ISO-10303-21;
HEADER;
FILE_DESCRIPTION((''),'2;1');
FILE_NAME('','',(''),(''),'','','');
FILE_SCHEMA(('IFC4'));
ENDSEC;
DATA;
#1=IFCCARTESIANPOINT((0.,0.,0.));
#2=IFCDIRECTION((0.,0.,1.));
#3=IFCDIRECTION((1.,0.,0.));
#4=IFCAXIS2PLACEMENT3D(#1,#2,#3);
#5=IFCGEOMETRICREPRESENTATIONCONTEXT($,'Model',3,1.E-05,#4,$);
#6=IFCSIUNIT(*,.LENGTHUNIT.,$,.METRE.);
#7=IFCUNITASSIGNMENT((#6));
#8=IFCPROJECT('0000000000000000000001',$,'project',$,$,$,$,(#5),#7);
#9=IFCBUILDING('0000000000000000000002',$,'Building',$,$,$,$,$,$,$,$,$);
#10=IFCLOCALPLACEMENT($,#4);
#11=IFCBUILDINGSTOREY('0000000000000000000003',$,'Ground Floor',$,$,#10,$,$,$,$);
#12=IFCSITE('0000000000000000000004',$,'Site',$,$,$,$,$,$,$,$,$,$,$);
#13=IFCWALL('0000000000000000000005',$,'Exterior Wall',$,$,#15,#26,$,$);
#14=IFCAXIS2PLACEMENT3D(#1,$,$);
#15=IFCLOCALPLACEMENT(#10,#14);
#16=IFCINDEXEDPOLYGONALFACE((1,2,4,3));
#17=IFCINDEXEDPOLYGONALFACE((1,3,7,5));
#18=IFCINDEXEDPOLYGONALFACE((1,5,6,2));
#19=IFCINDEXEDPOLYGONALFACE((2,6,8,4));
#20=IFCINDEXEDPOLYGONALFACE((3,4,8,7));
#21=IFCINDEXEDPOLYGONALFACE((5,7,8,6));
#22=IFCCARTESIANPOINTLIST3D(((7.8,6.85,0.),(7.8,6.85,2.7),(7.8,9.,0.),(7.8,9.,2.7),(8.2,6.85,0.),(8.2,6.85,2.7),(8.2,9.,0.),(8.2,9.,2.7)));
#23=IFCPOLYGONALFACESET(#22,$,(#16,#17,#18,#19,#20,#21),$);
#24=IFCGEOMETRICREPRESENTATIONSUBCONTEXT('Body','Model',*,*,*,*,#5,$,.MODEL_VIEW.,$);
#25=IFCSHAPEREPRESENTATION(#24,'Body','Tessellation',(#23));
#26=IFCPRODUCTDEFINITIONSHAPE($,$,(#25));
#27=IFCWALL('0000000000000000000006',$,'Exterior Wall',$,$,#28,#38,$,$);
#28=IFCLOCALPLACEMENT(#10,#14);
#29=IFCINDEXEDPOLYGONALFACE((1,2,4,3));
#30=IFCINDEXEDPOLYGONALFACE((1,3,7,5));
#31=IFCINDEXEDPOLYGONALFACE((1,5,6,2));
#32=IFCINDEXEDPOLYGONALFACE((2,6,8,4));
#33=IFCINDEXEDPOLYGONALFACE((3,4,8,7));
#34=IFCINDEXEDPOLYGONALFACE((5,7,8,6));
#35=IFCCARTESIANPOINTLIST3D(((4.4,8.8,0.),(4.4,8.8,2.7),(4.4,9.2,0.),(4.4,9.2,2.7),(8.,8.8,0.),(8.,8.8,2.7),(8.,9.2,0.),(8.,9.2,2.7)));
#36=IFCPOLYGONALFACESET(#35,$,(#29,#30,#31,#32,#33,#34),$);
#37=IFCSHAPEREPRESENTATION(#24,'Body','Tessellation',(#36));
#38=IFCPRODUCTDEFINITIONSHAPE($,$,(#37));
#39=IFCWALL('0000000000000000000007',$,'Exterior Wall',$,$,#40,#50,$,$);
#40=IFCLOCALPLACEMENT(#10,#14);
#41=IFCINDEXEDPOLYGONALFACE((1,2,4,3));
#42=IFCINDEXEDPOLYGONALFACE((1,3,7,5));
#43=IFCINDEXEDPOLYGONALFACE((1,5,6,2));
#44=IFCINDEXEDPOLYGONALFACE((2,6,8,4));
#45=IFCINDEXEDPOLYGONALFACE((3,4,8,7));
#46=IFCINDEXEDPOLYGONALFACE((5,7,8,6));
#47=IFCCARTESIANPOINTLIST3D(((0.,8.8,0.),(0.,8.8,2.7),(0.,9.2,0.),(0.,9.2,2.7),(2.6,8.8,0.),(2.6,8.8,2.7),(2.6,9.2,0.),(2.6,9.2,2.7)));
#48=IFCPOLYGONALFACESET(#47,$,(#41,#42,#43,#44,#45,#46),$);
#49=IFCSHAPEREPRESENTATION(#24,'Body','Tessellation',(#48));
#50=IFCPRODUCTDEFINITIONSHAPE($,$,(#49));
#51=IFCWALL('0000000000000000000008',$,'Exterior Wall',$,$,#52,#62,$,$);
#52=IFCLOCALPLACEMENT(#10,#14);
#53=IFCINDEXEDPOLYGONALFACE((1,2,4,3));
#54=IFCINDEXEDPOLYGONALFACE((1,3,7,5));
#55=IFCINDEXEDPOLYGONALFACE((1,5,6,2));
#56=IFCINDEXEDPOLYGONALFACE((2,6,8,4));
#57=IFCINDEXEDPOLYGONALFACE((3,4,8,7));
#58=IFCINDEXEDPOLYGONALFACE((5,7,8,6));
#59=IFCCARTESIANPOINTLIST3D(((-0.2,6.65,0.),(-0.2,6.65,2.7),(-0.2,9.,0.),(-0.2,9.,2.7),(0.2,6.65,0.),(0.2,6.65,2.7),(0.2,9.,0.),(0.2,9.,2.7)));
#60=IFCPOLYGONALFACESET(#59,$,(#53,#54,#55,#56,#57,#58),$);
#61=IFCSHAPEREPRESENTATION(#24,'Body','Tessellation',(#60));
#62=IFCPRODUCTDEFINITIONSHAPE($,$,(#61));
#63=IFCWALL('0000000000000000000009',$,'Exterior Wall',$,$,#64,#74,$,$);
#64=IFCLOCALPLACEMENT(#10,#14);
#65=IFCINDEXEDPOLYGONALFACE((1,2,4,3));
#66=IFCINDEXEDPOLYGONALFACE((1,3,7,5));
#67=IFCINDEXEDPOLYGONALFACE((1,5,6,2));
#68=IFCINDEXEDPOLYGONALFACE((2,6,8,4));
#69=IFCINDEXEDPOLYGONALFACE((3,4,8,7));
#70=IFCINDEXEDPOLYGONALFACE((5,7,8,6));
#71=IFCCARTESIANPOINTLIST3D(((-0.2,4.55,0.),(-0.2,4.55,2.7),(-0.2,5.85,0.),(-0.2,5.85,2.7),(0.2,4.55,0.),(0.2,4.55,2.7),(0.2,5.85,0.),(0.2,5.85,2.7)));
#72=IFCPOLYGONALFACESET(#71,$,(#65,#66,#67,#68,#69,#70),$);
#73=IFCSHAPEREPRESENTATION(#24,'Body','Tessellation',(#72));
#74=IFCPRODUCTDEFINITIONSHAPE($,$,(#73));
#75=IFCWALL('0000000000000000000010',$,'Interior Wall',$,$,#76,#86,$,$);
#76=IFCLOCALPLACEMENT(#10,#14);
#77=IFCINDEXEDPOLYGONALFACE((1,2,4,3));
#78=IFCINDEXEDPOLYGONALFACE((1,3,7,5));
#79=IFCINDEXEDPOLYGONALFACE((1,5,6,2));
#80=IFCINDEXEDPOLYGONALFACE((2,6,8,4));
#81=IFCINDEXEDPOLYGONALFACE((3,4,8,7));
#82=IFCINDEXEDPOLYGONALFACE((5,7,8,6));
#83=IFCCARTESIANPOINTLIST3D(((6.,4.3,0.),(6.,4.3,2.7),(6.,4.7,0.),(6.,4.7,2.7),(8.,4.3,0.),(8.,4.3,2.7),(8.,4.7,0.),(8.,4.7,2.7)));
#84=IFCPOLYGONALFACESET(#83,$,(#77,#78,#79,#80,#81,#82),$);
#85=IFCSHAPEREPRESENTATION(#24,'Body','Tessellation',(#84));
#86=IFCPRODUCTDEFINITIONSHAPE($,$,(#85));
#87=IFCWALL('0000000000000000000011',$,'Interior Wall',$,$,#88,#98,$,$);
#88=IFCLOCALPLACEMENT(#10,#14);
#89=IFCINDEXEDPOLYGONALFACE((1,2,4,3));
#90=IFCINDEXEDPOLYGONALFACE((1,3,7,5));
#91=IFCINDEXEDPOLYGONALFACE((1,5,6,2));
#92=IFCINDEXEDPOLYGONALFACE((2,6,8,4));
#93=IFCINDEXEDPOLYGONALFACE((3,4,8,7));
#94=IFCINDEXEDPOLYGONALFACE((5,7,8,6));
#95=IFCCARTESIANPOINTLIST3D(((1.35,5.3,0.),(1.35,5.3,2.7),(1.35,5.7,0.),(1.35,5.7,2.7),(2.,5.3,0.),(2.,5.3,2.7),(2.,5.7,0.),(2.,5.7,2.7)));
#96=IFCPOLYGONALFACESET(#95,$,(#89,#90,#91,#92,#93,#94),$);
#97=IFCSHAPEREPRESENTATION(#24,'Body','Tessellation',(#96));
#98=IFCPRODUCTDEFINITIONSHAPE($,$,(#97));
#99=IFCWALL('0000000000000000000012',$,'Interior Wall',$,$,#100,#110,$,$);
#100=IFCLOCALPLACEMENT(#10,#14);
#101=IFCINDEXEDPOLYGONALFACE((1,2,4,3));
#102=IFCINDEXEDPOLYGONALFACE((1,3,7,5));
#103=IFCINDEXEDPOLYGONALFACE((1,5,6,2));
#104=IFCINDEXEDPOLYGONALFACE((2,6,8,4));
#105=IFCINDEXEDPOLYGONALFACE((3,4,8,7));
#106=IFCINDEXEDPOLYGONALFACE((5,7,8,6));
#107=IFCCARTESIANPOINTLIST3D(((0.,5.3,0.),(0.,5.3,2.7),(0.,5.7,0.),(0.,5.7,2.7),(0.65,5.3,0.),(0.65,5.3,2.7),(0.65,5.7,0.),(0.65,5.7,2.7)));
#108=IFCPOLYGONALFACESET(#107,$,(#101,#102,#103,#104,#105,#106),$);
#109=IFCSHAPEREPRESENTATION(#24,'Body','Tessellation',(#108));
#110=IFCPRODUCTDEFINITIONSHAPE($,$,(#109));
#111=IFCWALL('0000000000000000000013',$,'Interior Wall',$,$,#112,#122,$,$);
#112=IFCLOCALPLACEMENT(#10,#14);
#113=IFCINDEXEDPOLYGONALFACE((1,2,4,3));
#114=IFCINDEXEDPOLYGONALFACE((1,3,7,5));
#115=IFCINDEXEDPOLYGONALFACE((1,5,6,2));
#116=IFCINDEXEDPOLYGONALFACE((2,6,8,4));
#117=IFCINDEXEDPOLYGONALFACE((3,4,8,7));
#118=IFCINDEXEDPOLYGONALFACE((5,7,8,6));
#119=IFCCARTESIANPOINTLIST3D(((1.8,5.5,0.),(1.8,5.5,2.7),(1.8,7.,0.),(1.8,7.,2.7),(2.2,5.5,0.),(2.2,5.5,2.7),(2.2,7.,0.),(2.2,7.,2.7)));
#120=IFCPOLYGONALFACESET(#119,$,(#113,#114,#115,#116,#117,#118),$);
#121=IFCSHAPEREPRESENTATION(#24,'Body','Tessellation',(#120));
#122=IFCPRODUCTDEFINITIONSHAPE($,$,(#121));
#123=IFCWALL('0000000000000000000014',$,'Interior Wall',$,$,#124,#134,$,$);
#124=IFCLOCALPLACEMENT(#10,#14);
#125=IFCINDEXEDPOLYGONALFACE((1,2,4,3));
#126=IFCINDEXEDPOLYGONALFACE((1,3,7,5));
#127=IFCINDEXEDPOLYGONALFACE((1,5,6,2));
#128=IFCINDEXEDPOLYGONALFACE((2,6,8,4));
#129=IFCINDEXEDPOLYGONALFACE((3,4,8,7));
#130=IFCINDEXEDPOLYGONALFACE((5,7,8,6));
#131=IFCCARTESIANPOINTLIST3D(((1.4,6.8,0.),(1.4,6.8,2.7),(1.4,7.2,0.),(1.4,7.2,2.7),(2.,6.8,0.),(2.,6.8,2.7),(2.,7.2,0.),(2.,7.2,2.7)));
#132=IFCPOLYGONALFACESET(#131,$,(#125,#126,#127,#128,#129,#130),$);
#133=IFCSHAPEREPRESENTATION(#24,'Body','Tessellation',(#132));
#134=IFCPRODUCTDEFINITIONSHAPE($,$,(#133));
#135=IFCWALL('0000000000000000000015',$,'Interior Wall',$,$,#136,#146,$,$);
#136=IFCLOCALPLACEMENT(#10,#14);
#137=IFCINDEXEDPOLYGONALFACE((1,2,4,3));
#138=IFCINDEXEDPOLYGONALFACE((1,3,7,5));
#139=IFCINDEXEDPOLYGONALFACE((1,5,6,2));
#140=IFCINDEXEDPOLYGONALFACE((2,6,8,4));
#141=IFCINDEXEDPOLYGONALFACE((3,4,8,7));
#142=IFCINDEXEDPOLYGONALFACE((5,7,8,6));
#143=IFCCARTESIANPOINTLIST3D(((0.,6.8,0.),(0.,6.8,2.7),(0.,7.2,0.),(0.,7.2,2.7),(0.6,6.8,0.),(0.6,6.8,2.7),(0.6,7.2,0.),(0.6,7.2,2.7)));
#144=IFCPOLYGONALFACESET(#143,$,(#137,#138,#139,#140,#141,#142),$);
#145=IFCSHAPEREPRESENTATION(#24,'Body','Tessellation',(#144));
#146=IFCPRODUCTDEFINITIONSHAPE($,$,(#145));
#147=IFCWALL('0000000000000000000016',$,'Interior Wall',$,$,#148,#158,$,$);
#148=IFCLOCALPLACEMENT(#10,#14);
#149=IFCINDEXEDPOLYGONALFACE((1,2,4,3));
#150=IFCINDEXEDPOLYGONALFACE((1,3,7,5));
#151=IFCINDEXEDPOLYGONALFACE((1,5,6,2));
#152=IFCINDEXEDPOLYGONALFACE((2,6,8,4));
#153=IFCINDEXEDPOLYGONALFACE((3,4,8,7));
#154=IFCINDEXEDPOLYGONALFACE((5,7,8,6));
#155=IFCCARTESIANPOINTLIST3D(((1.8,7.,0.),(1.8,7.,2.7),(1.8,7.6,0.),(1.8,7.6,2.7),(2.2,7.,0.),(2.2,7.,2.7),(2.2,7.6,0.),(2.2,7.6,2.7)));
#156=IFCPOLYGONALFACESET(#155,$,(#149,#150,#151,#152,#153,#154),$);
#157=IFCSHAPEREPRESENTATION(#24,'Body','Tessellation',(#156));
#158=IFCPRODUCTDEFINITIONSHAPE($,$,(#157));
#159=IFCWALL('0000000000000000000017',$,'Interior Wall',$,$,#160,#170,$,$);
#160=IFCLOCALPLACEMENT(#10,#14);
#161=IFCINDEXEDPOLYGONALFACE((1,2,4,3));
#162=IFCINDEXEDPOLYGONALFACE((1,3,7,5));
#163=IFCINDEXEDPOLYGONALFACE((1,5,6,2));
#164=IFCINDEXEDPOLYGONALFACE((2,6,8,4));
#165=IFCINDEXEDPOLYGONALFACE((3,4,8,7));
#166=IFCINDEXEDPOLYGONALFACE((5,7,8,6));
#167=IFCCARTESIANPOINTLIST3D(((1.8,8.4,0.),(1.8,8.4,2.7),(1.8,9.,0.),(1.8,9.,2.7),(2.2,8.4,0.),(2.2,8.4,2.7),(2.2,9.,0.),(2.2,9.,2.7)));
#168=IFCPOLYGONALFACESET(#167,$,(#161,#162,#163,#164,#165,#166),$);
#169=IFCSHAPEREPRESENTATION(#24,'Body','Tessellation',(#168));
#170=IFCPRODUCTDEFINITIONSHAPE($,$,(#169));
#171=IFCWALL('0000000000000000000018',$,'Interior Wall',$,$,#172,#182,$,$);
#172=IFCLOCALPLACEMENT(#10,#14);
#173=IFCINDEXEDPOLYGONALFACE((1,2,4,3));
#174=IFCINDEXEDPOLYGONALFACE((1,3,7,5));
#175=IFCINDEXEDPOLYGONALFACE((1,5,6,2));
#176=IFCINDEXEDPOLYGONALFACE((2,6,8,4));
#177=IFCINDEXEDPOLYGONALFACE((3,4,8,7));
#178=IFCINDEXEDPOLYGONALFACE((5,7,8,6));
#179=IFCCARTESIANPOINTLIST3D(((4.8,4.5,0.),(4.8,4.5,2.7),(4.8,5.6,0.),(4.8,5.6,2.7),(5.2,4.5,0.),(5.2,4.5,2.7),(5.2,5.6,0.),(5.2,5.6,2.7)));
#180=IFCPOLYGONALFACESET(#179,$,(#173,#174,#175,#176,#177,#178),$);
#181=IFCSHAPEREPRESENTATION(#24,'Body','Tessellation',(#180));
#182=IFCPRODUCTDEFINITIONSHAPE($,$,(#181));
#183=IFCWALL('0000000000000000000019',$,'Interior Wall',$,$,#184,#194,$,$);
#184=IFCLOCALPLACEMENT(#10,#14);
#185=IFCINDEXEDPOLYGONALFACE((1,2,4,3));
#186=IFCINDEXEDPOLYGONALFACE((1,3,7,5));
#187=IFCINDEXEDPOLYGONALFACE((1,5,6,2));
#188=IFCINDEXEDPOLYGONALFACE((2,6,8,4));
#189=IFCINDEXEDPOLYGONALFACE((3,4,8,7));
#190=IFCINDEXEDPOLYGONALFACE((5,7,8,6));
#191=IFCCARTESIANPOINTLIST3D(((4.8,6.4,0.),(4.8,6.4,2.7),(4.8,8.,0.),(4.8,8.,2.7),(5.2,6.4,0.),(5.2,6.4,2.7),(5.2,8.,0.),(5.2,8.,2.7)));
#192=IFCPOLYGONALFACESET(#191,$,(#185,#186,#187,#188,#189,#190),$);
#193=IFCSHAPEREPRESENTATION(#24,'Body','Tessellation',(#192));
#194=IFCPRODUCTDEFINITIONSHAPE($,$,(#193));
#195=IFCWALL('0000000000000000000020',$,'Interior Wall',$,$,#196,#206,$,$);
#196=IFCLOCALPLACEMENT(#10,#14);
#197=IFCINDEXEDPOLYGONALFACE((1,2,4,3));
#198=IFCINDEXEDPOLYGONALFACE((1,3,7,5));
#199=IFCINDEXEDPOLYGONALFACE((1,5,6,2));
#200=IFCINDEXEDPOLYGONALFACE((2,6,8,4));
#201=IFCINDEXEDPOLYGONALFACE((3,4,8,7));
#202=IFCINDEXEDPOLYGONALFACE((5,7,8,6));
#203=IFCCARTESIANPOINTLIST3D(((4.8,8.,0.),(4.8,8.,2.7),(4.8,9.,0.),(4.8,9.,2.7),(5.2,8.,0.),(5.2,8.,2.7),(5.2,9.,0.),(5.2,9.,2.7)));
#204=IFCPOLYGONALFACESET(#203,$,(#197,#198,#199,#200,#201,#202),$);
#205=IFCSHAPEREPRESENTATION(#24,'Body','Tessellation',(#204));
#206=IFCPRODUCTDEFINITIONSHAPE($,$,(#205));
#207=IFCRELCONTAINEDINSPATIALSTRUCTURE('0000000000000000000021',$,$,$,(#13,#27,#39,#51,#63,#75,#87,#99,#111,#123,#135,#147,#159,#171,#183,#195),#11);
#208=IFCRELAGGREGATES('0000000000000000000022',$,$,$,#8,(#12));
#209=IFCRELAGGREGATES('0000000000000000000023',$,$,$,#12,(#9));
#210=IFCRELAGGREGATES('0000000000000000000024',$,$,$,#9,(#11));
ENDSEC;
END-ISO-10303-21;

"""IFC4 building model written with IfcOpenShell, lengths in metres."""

from ifc_helpers import new_model, si_unit, frame, origin_with_axes, place, context, subcontext, project, spatial, indexed_curve, outline, extrude, element, save


model = new_model("IFC4")

# Units and contexts
model_context = context("Model", 3, precision=1e-05, world=origin_with_axes())
body_context = subcontext(model_context, "Body", "Model", "MODEL_VIEW")
ifc_project = project(units=[si_unit("LENGTHUNIT", "METRE")], contexts=[model_context])

# Site, building, storey
site = spatial("IfcSite", under=ifc_project, Name="Site")
building = spatial("IfcBuilding", under=site, Name="Building")
storey_placement = place(None, origin_with_axes())
storey = spatial("IfcBuildingStorey", under=building, at=storey_placement, Name="Ground Floor")

# Walls
wall_1_placement = place(storey_placement, frame((8.0, 6.85, 0.0), z_axis=(0.0, 0.0, 1.0), x_axis=(0.0, 1.0, 0.0)))
element("IfcWall", 1, at=wall_1_placement, inside=storey, Name="Exterior Wall", context=body_context, shape_type="SweptSolid", body=[
    extrude(outline(indexed_curve([(0.0, 0.0), (0.0, 0.4), (2.15, 0.4), (2.15, 0.0), (0.0, 0.0)], self_intersect=False)), frame((0.0, -0.2, 0.0), z_axis=(0.0, 0.0, 1.0), x_axis=(1.0, 0.0, 0.0)), (0.0, 0.0, 1.0), 2.7),
])
wall_2_placement = place(storey_placement, frame((8.0, 9.0, 0.0), z_axis=(0.0, 0.0, 1.0), x_axis=(-1.0, 0.0, 0.0)))
element("IfcWall", 2, at=wall_2_placement, inside=storey, Name="Exterior Wall", context=body_context, shape_type="SweptSolid", body=[
    extrude(outline(indexed_curve([(0.0, 0.0), (0.0, 0.4), (3.6, 0.4), (3.6, 0.0), (0.0, 0.0)], self_intersect=False)), frame((0.0, -0.2, 0.0), z_axis=(0.0, 0.0, 1.0), x_axis=(1.0, 0.0, 0.0)), (0.0, 0.0, 1.0), 2.7),
])
wall_3_placement = place(storey_placement, frame((2.6, 9.0, 0.0), z_axis=(0.0, 0.0, 1.0), x_axis=(-1.0, 0.0, 0.0)))
element("IfcWall", 3, at=wall_3_placement, inside=storey, Name="Exterior Wall", context=body_context, shape_type="SweptSolid", body=[
    extrude(outline(indexed_curve([(0.0, 0.0), (0.0, 0.4), (2.6, 0.4), (2.6, 0.0), (0.0, 0.0)], self_intersect=False)), frame((0.0, -0.2, 0.0), z_axis=(0.0, 0.0, 1.0), x_axis=(1.0, 0.0, 0.0)), (0.0, 0.0, 1.0), 2.7),
])
wall_4_placement = place(storey_placement, frame((0.0, 9.0, 0.0), z_axis=(0.0, 0.0, 1.0), x_axis=(0.0, -1.0, 0.0)))
element("IfcWall", 4, at=wall_4_placement, inside=storey, Name="Exterior Wall", context=body_context, shape_type="SweptSolid", body=[
    extrude(outline(indexed_curve([(0.0, 0.0), (0.0, 0.4), (2.35, 0.4), (2.35, 0.0), (0.0, 0.0)], self_intersect=False)), frame((0.0, -0.2, 0.0), z_axis=(0.0, 0.0, 1.0), x_axis=(1.0, 0.0, 0.0)), (0.0, 0.0, 1.0), 2.7),
])
wall_5_placement = place(storey_placement, frame((0.0, 5.85, 0.0), z_axis=(0.0, 0.0, 1.0), x_axis=(0.0, -1.0, 0.0)))
element("IfcWall", 5, at=wall_5_placement, inside=storey, Name="Exterior Wall", context=body_context, shape_type="SweptSolid", body=[
    extrude(outline(indexed_curve([(0.0, 0.0), (0.0, 0.4), (1.3, 0.4), (1.3, 0.0), (0.0, 0.0)], self_intersect=False)), frame((0.0, -0.2, 0.0), z_axis=(0.0, 0.0, 1.0), x_axis=(1.0, 0.0, 0.0)), (0.0, 0.0, 1.0), 2.7),
])
wall_6_placement = place(storey_placement, frame((8.0, 4.5, 0.0), z_axis=(0.0, 0.0, 1.0), x_axis=(-1.0, 0.0, 0.0)))
element("IfcWall", 6, at=wall_6_placement, inside=storey, Name="Interior Wall", context=body_context, shape_type="SweptSolid", body=[
    extrude(outline(indexed_curve([(0.0, 0.0), (0.0, 0.4), (2.0, 0.4), (2.0, 0.0), (0.0, 0.0)], self_intersect=False)), frame((0.0, -0.2, 0.0), z_axis=(0.0, 0.0, 1.0), x_axis=(1.0, 0.0, 0.0)), (0.0, 0.0, 1.0), 2.7),
])
for number, where, z_axis, x_axis, name in (
    (7, (2.0, 5.5, 0.0), (0.0, 0.0, 1.0), (-1.0, 0.0, 0.0), "Interior Wall"),
    (8, (0.65, 5.5, 0.0), (0.0, 0.0, 1.0), (-1.0, 0.0, 0.0), "Interior Wall"),
):
    element("IfcWall", number, at=place(storey_placement, frame(where, z_axis=z_axis, x_axis=x_axis)), inside=storey, Name=name, context=body_context, shape_type="SweptSolid", body=[
        extrude(outline(indexed_curve([(0.0, 0.0), (0.0, 0.4), (0.65, 0.4), (0.65, 0.0), (0.0, 0.0)], self_intersect=False)), frame((0.0, -0.2, 0.0), z_axis=(0.0, 0.0, 1.0), x_axis=(1.0, 0.0, 0.0)), (0.0, 0.0, 1.0), 2.7),
    ])
wall_7_placement = place(storey_placement, frame((2.0, 5.5, 0.0), z_axis=(0.0, 0.0, 1.0), x_axis=(0.0, 1.0, 0.0)))
element("IfcWall", 9, at=wall_7_placement, inside=storey, Name="Interior Wall", context=body_context, shape_type="SweptSolid", body=[
    extrude(outline(indexed_curve([(0.0, 0.0), (0.0, 0.4), (1.5, 0.4), (1.5, 0.0), (0.0, 0.0)], self_intersect=False)), frame((0.0, -0.2, 0.0), z_axis=(0.0, 0.0, 1.0), x_axis=(1.0, 0.0, 0.0)), (0.0, 0.0, 1.0), 2.7),
])
for number, where, z_axis, x_axis, name in (
    (10, (2.0, 7.0, 0.0), (0.0, 0.0, 1.0), (-1.0, 0.0, 0.0), "Interior Wall"),
    (11, (0.6, 7.0, 0.0), (0.0, 0.0, 1.0), (-1.0, 0.0, 0.0), "Interior Wall"),
):
    element("IfcWall", number, at=place(storey_placement, frame(where, z_axis=z_axis, x_axis=x_axis)), inside=storey, Name=name, context=body_context, shape_type="SweptSolid", body=[
        extrude(outline(indexed_curve([(0.0, 0.0), (0.0, 0.4), (0.6, 0.4), (0.6, 0.0), (0.0, 0.0)], self_intersect=False)), frame((0.0, -0.2, 0.0), z_axis=(0.0, 0.0, 1.0), x_axis=(1.0, 0.0, 0.0)), (0.0, 0.0, 1.0), 2.7),
    ])
for number, where, z_axis, x_axis, name in (
    (12, (2.0, 7.0, 0.0), (0.0, 0.0, 1.0), (0.0, 1.0, 0.0), "Interior Wall"),
    (13, (2.0, 8.4, 0.0), (0.0, 0.0, 1.0), (0.0, 1.0, 0.0), "Interior Wall"),
):
    element("IfcWall", number, at=place(storey_placement, frame(where, z_axis=z_axis, x_axis=x_axis)), inside=storey, Name=name, context=body_context, shape_type="SweptSolid", body=[
        extrude(outline(indexed_curve([(0.0, 0.0), (0.0, 0.4), (0.6, 0.4), (0.6, 0.0), (0.0, 0.0)], self_intersect=False)), frame((0.0, -0.2, 0.0), z_axis=(0.0, 0.0, 1.0), x_axis=(1.0, 0.0, 0.0)), (0.0, 0.0, 1.0), 2.7),
    ])
wall_8_placement = place(storey_placement, frame((5.0, 4.5, 0.0), z_axis=(0.0, 0.0, 1.0), x_axis=(0.0, 1.0, 0.0)))
element("IfcWall", 14, at=wall_8_placement, inside=storey, Name="Interior Wall", context=body_context, shape_type="SweptSolid", body=[
    extrude(outline(indexed_curve([(0.0, 0.0), (0.0, 0.4), (1.1, 0.4), (1.1, 0.0), (0.0, 0.0)], self_intersect=False)), frame((0.0, -0.2, 0.0), z_axis=(0.0, 0.0, 1.0), x_axis=(1.0, 0.0, 0.0)), (0.0, 0.0, 1.0), 2.7),
])
wall_9_placement = place(storey_placement, frame((5.0, 6.4, 0.0), z_axis=(0.0, 0.0, 1.0), x_axis=(0.0, 1.0, 0.0)))
element("IfcWall", 15, at=wall_9_placement, inside=storey, Name="Interior Wall", context=body_context, shape_type="SweptSolid", body=[
    extrude(outline(indexed_curve([(0.0, 0.0), (0.0, 0.4), (1.6, 0.4), (1.6, 0.0), (0.0, 0.0)], self_intersect=False)), frame((0.0, -0.2, 0.0), z_axis=(0.0, 0.0, 1.0), x_axis=(1.0, 0.0, 0.0)), (0.0, 0.0, 1.0), 2.7),
])
wall_10_placement = place(storey_placement, frame((5.0, 8.0, 0.0), z_axis=(0.0, 0.0, 1.0), x_axis=(0.0, 1.0, 0.0)))
element("IfcWall", 16, at=wall_10_placement, inside=storey, Name="Interior Wall", context=body_context, shape_type="SweptSolid", body=[
    extrude(outline(indexed_curve([(0.0, 0.0), (0.0, 0.4), (1.0, 0.4), (1.0, 0.0), (0.0, 0.0)], self_intersect=False)), frame((0.0, -0.2, 0.0), z_axis=(0.0, 0.0, 1.0), x_axis=(1.0, 0.0, 0.0)), (0.0, 0.0, 1.0), 2.7),
])

save(model, "model.ifc")
